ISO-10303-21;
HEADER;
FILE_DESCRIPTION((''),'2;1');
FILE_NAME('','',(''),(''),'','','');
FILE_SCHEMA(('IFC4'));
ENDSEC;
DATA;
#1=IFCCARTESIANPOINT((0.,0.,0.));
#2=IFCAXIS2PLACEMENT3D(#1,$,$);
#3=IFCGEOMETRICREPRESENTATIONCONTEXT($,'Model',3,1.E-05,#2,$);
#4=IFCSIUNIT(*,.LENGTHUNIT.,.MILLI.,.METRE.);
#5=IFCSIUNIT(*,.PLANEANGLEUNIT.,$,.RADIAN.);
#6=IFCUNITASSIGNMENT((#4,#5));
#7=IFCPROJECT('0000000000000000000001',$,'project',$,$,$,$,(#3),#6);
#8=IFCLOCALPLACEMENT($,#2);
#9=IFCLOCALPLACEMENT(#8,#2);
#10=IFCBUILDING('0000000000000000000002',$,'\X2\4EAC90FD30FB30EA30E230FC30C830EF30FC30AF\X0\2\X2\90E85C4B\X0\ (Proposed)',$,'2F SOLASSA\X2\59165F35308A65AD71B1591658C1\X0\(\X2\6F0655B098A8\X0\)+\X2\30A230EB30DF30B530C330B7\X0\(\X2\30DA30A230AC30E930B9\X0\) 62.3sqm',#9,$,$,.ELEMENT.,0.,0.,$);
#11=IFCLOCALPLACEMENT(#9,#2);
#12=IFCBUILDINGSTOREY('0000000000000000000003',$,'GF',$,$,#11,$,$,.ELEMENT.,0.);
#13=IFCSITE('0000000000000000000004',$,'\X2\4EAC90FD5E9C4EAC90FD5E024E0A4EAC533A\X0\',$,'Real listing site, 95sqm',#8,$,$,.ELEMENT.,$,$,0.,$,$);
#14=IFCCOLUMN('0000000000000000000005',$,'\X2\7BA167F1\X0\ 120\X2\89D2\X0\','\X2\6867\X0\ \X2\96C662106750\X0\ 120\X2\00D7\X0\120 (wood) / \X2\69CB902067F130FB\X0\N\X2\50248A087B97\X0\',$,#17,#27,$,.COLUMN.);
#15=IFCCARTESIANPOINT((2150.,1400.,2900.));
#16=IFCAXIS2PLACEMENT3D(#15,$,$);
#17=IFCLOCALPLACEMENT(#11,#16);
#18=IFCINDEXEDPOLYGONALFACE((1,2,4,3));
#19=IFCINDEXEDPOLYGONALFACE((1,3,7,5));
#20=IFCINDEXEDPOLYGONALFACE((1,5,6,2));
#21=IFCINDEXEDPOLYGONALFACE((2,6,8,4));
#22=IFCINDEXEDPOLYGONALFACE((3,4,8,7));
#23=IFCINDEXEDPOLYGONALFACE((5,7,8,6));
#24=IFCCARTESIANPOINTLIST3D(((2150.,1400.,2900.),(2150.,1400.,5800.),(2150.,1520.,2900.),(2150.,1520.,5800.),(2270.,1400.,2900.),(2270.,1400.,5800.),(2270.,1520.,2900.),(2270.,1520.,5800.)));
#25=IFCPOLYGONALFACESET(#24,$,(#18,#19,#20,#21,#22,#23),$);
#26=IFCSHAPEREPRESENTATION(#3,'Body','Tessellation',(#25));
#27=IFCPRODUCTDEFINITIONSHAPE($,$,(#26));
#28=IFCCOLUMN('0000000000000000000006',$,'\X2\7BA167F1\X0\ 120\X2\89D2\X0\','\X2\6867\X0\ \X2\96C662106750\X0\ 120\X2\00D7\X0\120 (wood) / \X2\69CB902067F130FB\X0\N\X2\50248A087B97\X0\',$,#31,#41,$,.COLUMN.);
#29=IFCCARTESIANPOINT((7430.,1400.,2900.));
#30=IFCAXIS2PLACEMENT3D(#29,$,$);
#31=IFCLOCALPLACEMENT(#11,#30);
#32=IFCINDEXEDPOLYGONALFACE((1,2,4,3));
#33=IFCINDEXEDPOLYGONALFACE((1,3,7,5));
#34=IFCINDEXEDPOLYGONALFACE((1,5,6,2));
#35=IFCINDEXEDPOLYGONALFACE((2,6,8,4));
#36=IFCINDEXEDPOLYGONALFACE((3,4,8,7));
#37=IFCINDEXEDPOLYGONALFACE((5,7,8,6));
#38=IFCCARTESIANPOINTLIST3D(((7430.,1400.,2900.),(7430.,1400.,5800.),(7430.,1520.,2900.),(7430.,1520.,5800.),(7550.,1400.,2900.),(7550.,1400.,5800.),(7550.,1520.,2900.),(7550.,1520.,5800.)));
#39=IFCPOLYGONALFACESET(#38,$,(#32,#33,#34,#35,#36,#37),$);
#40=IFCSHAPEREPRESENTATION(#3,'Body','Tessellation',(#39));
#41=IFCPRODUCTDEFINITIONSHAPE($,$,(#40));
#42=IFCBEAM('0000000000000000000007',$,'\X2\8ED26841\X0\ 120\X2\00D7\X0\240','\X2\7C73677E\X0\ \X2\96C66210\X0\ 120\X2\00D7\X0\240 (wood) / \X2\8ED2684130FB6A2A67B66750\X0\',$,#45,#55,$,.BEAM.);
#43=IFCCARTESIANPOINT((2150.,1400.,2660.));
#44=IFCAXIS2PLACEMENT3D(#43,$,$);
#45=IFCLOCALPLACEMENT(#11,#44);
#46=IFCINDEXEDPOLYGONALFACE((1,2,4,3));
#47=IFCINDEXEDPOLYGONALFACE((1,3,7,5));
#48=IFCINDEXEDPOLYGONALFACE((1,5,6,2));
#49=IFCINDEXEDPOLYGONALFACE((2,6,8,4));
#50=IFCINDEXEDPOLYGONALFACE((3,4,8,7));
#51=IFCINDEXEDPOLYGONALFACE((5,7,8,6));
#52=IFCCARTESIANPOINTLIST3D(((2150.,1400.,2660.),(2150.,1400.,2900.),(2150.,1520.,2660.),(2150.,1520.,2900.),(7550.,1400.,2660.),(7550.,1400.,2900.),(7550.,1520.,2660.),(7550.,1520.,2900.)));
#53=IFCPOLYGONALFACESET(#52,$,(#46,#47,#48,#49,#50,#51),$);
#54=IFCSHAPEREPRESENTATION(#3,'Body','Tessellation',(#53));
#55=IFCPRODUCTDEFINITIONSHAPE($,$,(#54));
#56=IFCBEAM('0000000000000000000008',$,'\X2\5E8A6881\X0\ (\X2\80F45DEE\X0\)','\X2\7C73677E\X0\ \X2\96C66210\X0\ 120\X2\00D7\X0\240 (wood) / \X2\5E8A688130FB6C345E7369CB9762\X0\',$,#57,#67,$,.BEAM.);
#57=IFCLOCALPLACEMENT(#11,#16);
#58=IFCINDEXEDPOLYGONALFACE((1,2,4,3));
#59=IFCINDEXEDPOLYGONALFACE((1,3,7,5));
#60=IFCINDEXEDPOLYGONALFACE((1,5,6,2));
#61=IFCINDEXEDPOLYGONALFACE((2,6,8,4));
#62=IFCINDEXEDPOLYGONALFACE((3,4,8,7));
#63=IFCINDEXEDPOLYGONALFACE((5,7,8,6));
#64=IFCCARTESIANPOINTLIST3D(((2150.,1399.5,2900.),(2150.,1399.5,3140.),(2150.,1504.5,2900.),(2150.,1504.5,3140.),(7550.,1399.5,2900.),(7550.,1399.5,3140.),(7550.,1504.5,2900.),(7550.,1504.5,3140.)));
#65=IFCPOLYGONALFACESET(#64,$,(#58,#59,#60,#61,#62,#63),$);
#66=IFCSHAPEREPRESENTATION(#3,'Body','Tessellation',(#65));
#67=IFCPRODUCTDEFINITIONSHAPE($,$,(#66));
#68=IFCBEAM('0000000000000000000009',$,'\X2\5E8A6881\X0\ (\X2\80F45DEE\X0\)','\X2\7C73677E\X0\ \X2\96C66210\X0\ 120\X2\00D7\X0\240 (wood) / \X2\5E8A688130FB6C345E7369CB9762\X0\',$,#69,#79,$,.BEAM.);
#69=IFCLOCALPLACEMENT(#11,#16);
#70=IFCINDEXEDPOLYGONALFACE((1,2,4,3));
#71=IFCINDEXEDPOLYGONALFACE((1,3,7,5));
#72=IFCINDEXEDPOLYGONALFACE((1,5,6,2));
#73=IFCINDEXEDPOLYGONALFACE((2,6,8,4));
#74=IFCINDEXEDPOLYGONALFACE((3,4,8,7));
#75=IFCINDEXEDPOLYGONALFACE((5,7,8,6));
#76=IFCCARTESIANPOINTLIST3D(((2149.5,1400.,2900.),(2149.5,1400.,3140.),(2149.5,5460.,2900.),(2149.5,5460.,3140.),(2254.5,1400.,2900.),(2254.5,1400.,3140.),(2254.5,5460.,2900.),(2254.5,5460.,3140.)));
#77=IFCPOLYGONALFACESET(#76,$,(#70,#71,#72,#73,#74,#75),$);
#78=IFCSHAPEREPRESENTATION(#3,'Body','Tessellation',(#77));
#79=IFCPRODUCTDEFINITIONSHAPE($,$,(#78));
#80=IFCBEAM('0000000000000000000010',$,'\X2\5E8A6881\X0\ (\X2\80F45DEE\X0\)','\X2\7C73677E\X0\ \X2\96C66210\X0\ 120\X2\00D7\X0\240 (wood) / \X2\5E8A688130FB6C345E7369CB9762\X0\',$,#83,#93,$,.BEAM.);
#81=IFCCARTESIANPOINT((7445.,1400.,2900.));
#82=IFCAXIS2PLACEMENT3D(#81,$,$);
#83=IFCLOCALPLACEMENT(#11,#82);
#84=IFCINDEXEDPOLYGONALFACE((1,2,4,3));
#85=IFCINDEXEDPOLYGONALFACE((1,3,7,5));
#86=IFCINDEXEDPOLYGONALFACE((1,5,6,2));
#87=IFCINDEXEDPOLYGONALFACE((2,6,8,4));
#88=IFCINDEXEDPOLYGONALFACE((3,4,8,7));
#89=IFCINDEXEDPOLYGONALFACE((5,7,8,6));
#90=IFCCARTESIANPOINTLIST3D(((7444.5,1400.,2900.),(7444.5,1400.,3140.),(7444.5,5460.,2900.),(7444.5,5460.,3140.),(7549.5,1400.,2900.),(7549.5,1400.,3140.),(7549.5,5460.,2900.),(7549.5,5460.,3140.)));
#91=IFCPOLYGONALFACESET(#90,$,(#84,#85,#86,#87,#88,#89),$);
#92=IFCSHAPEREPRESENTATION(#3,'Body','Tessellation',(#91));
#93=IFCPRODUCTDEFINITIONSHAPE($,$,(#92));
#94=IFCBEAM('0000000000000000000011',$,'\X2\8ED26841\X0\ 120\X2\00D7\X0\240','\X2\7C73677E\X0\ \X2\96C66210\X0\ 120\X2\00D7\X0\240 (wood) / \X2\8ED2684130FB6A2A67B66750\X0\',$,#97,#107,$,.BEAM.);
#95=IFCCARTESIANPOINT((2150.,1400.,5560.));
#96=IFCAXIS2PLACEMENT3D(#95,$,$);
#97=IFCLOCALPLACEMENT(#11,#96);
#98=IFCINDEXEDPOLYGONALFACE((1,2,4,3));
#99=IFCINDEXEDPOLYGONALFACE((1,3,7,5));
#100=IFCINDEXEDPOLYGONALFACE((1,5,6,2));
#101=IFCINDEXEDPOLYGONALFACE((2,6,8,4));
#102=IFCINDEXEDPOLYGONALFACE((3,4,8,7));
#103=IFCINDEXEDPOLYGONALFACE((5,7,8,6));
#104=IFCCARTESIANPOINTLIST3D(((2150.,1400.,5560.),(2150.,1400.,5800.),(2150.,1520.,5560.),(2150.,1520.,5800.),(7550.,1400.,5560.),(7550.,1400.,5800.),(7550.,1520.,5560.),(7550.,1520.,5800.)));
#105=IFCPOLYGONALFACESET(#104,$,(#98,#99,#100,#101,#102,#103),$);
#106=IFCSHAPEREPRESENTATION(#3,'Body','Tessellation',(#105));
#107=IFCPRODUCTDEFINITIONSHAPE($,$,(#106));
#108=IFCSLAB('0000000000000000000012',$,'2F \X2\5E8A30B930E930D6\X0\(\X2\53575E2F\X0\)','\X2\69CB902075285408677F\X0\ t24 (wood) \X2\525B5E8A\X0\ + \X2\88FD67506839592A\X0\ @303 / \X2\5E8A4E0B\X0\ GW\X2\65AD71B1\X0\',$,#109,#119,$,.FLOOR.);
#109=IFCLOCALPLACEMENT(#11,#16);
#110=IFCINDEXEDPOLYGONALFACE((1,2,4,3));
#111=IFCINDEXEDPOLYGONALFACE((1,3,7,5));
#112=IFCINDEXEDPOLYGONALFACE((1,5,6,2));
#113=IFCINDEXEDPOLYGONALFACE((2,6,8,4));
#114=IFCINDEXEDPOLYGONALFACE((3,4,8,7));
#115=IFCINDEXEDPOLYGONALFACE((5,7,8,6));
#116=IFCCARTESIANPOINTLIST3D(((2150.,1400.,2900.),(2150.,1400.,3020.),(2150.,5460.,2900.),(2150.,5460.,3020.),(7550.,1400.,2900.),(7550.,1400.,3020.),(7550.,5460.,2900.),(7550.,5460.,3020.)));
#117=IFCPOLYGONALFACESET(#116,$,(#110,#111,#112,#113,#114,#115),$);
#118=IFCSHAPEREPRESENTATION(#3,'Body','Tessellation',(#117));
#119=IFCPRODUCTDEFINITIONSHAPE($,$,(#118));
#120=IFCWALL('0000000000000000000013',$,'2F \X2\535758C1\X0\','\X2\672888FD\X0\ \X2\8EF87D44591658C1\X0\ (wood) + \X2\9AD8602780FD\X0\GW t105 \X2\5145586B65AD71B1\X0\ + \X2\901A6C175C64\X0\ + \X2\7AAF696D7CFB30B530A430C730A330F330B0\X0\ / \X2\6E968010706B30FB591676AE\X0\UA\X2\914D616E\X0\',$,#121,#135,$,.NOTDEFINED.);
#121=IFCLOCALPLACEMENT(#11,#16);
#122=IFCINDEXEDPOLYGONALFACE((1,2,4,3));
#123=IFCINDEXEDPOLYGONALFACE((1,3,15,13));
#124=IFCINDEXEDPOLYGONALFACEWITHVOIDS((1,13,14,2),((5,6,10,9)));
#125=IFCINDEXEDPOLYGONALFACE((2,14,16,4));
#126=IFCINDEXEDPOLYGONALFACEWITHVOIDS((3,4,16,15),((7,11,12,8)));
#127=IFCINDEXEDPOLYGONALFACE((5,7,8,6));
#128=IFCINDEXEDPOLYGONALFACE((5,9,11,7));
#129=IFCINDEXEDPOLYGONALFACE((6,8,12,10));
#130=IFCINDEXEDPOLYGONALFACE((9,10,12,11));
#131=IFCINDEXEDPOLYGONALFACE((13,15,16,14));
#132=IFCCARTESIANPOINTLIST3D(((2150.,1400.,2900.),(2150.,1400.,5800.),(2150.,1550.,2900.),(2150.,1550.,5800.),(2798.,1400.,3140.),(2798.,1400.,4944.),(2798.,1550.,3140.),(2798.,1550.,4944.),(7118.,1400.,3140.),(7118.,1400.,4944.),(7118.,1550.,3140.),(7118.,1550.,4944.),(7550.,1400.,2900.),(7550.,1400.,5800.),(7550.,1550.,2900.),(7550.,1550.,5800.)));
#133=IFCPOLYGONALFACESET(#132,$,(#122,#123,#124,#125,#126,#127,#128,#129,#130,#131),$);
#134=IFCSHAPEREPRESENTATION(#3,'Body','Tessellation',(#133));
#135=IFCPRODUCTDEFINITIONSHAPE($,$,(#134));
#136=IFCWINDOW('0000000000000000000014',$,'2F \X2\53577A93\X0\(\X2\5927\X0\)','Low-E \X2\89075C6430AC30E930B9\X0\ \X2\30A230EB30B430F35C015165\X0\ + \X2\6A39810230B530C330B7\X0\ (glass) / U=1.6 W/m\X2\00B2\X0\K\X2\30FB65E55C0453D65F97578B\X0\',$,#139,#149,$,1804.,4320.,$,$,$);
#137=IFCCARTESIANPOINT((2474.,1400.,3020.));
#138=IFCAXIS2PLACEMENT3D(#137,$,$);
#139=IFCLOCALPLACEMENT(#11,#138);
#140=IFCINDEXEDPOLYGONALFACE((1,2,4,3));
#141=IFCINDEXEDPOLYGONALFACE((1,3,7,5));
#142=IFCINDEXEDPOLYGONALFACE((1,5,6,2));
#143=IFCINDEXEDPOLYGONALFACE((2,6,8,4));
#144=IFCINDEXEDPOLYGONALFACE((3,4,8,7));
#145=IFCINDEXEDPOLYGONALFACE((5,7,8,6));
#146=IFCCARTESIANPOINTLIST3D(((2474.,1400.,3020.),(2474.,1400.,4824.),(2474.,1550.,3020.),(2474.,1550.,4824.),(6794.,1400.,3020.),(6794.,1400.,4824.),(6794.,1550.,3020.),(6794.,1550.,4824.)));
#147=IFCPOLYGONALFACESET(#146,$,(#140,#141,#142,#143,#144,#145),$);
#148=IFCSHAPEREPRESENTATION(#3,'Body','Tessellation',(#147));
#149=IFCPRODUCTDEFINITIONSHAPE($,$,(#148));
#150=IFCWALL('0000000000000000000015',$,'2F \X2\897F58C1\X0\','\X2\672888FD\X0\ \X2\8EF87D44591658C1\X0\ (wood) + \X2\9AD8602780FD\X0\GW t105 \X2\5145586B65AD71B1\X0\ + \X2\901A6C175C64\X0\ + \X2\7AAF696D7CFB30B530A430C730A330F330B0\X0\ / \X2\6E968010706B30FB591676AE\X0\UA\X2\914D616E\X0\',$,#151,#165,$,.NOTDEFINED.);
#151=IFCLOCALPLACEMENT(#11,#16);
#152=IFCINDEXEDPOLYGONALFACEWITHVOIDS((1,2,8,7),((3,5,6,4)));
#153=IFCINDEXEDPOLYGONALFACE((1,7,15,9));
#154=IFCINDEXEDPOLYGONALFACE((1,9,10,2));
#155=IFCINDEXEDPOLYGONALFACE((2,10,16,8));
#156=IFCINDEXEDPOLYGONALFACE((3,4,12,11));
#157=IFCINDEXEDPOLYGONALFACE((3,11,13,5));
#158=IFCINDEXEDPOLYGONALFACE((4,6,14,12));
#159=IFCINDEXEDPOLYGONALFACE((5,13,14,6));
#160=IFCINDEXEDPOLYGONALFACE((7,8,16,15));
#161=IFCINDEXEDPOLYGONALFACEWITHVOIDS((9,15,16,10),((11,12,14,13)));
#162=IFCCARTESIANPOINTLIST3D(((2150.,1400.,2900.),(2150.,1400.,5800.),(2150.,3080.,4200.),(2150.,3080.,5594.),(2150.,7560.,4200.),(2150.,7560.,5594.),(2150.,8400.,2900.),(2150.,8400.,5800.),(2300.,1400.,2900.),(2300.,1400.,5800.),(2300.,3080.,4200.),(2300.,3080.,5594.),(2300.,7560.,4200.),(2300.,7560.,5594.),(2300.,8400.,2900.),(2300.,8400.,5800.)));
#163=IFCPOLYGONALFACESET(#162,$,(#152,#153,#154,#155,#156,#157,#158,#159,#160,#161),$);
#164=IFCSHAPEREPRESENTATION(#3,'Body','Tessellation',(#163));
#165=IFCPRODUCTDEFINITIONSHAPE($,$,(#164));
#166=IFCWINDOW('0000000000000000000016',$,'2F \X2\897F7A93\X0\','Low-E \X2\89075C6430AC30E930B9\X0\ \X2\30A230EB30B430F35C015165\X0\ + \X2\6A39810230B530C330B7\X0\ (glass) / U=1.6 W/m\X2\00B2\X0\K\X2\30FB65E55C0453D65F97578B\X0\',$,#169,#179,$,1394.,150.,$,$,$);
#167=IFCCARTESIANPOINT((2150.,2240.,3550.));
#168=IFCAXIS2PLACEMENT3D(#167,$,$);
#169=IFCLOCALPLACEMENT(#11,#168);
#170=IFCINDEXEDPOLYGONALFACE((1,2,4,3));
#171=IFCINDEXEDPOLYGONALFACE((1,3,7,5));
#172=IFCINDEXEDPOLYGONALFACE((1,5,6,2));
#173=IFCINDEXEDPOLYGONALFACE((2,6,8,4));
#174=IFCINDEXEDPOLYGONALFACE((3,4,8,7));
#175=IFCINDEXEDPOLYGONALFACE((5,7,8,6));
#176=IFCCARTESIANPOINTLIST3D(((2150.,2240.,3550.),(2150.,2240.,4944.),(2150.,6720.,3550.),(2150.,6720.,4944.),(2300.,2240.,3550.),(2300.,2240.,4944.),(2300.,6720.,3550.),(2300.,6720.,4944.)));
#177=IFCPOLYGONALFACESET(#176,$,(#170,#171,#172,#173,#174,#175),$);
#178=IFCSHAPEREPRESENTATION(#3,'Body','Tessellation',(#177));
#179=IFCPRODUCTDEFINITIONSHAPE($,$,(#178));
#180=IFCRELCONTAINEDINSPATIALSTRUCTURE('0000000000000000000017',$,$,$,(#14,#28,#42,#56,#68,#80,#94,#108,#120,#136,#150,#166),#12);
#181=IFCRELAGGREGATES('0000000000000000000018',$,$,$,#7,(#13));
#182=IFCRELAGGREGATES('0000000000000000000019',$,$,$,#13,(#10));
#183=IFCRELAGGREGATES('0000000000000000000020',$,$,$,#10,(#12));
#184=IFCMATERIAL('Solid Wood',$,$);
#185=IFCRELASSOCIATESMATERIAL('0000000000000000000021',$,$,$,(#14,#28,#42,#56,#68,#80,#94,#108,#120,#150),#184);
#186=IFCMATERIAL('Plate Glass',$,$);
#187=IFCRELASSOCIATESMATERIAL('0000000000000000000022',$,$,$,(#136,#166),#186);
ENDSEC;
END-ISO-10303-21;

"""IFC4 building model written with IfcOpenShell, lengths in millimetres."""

from ifc_helpers import new_model, si_unit, frame, frame_2d, origin, place, context, project, spatial, rectangle, extrude, material, element, fill, save


model = new_model("IFC4")

# Units and contexts
model_context = context("Model", 3, precision=1e-05, world=origin())
ifc_project = project(units=[si_unit("LENGTHUNIT", "METRE", prefix="MILLI"), si_unit("PLANEANGLEUNIT", "RADIAN")], contexts=[model_context])

# Site, building, storey
site_placement = place(None, origin())
site = spatial("IfcSite", under=ifc_project, at=site_placement, Name="京都府京都市上京区", ObjectType="Real listing site, 95sqm", CompositionType="ELEMENT", RefElevation=0.0)
building_placement = place(site_placement, origin())
building = spatial("IfcBuilding", under=site, at=building_placement, Name="京都・リモートワーク2部屋 (Proposed)", ObjectType="2F SOLASSA外張り断熱外壁(漆喰風)+アルミサッシ(ペアガラス) 62.3sqm", CompositionType="ELEMENT", ElevationOfRefHeight=0.0, ElevationOfTerrain=0.0)
storey_placement = place(building_placement, origin())
storey = spatial("IfcBuildingStorey", under=building, at=storey_placement, Name="GF", CompositionType="ELEMENT", Elevation=0.0)

# Columns
ifc_material_1 = material(Name="Solid Wood")
column_1_placement = place(storey_placement, frame((2150.0, 1400.0, 2900.0)))
element("IfcColumn", 1, at=column_1_placement, inside=storey, material=ifc_material_1, Name="管柱 120角", Description="桧 集成材 120×120 (wood) / 構造柱・N値計算", PredefinedType="COLUMN", context=model_context, shape_type="SweptSolid", body=[
    extrude(rectangle(XDim=120.0, YDim=120.0, at=frame_2d((60.0, 60.0))), frame((2150.0, 1400.0, 2900.0)), (0.0, 0.0, 1.0), 2900.0),
])
column_2_placement = place(storey_placement, frame((7430.0, 1400.0, 2900.0)))
element("IfcColumn", 2, at=column_2_placement, inside=storey, material=ifc_material_1, Name="管柱 120角", Description="桧 集成材 120×120 (wood) / 構造柱・N値計算", PredefinedType="COLUMN", context=model_context, shape_type="SweptSolid", body=[
    extrude(rectangle(XDim=120.0, YDim=120.0, at=frame_2d((60.0, 60.0))), frame((7430.0, 1400.0, 2900.0)), (0.0, 0.0, 1.0), 2900.0),
])

# Beams
beam_1_placement = place(storey_placement, frame((2150.0, 1400.0, 2660.0)))
element("IfcBeam", 3, at=beam_1_placement, inside=storey, material=ifc_material_1, Name="軒桁 120×240", Description="米松 集成 120×240 (wood) / 軒桁・横架材", PredefinedType="BEAM", context=model_context, shape_type="SweptSolid", body=[
    extrude(rectangle(XDim=5400.0, YDim=120.0, at=frame_2d((2700.0, 60.0))), frame((2150.0, 1400.0, 2660.0)), (0.0, 0.0, 1.0), 240.0),
])
beam_2_placement = place(storey_placement, frame((2150.0, 1400.0, 2900.0)))
element("IfcBeam", 4, at=beam_2_placement, inside=storey, material=ifc_material_1, Name="床梁 (胴差)", Description="米松 集成 120×240 (wood) / 床梁・水平構面", PredefinedType="BEAM", context=model_context, shape_type="SweptSolid", body=[
    extrude(rectangle(XDim=5400.0, YDim=105.0, at=frame_2d((2700.0, 52.0))), frame((2150.0, 1400.0, 2900.0)), (0.0, 0.0, 1.0), 240.0),
])
beam_3_placement = place(storey_placement, frame((2150.0, 1400.0, 2900.0)))
element("IfcBeam", 5, at=beam_3_placement, inside=storey, material=ifc_material_1, Name="床梁 (胴差)", Description="米松 集成 120×240 (wood) / 床梁・水平構面", PredefinedType="BEAM", context=model_context, shape_type="SweptSolid", body=[
    extrude(rectangle(XDim=105.0, YDim=4060.0, at=frame_2d((52.0, 2030.0))), frame((2150.0, 1400.0, 2900.0)), (0.0, 0.0, 1.0), 240.0),
])
beam_4_placement = place(storey_placement, frame((7445.0, 1400.0, 2900.0)))
element("IfcBeam", 6, at=beam_4_placement, inside=storey, material=ifc_material_1, Name="床梁 (胴差)", Description="米松 集成 120×240 (wood) / 床梁・水平構面", PredefinedType="BEAM", context=model_context, shape_type="SweptSolid", body=[
    extrude(rectangle(XDim=105.0, YDim=4060.0, at=frame_2d((52.0, 2030.0))), frame((7445.0, 1400.0, 2900.0)), (0.0, 0.0, 1.0), 240.0),
])
beam_5_placement = place(storey_placement, frame((2150.0, 1400.0, 5560.0)))
element("IfcBeam", 7, at=beam_5_placement, inside=storey, material=ifc_material_1, Name="軒桁 120×240", Description="米松 集成 120×240 (wood) / 軒桁・横架材", PredefinedType="BEAM", context=model_context, shape_type="SweptSolid", body=[
    extrude(rectangle(XDim=5400.0, YDim=120.0, at=frame_2d((2700.0, 60.0))), frame((2150.0, 1400.0, 5560.0)), (0.0, 0.0, 1.0), 240.0),
])

# Slab
slab_placement = place(storey_placement, frame((2150.0, 1400.0, 2900.0)))
element("IfcSlab", 8, at=slab_placement, inside=storey, material=ifc_material_1, Name="2F 床スラブ(南帯)", Description="構造用合板 t24 (wood) 剛床 + 製材根太 @303 / 床下 GW断熱", PredefinedType="FLOOR", context=model_context, shape_type="SweptSolid", body=[
    extrude(rectangle(XDim=5400.0, YDim=4060.0, at=frame_2d((2700.0, 2030.0))), frame((2150.0, 1400.0, 2900.0)), (0.0, 0.0, 1.0), 120.0),
])

# Walls, openings, windows
wall_1_placement = place(storey_placement, frame((2150.0, 1400.0, 2900.0)))
wall_1 = element("IfcWall", 9, at=wall_1_placement, inside=storey, material=ifc_material_1, Name="2F 南壁", Description="木製 軸組外壁 (wood) + 高性能GW t105 充填断熱 + 通気層 + 窯業系サイディング / 準耐火・外皮UA配慮", PredefinedType="NOTDEFINED", context=model_context, shape_type="SweptSolid", body=[
    extrude(rectangle(XDim=5400.0, YDim=150.0, at=frame_2d((2700.0, 75.0))), frame((2150.0, 1400.0, 2900.0)), (0.0, 0.0, 1.0), 2900.0),
])
opening_1_placement = place(storey_placement, frame((2474.0, 1400.0, 3020.0)))
opening_1 = element("IfcOpeningElement", 10, at=opening_1_placement, cuts=wall_1, PredefinedType="NOTDEFINED", context=model_context, shape_type="SweptSolid", body=[
    extrude(rectangle(XDim=4320.0, YDim=150.0, at=frame_2d((2160.0, 75.0))), frame((2474.0, 1400.0, 3020.0)), (0.0, 0.0, 1.0), 1804.0),
])
ifc_material_2 = material(Name="Plate Glass")
window_1_placement = place(storey_placement, frame((2474.0, 1400.0, 3020.0)))
window_1 = element("IfcWindow", 11, at=window_1_placement, inside=storey, material=ifc_material_2, Name="2F 南窓(大)", Description="Low-E 複層ガラス アルゴン封入 + 樹脂サッシ (glass) / U=1.6 W/m²K・日射取得型", OverallHeight=1804.0, OverallWidth=4320.0, context=model_context, shape_type="SweptSolid", body=[
    extrude(rectangle(XDim=4320.0, YDim=150.0, at=frame_2d((2160.0, 75.0))), frame((2474.0, 1400.0, 3020.0)), (0.0, 0.0, 1.0), 1804.0),
])
fill(opening_1, window_1)
wall_2_placement = place(storey_placement, frame((2150.0, 1400.0, 2900.0)))
wall_2 = element("IfcWall", 12, at=wall_2_placement, inside=storey, material=ifc_material_1, Name="2F 西壁", Description="木製 軸組外壁 (wood) + 高性能GW t105 充填断熱 + 通気層 + 窯業系サイディング / 準耐火・外皮UA配慮", PredefinedType="NOTDEFINED", context=model_context, shape_type="SweptSolid", body=[
    extrude(rectangle(XDim=150.0, YDim=7000.0, at=frame_2d((75.0, 3500.0))), frame((2150.0, 1400.0, 2900.0)), (0.0, 0.0, 1.0), 2900.0),
])
opening_2_placement = place(storey_placement, frame((2150.0, 2240.0, 3550.0)))
opening_2 = element("IfcOpeningElement", 13, at=opening_2_placement, cuts=wall_2, PredefinedType="NOTDEFINED", context=model_context, shape_type="SweptSolid", body=[
    extrude(rectangle(XDim=150.0, YDim=4480.0, at=frame_2d((75.0, 2240.0))), frame((2150.0, 2240.0, 3550.0)), (0.0, 0.0, 1.0), 1394.0),
])
window_2_placement = place(storey_placement, frame((2150.0, 2240.0, 3550.0)))
window_2 = element("IfcWindow", 14, at=window_2_placement, inside=storey, material=ifc_material_2, Name="2F 西窓", Description="Low-E 複層ガラス アルゴン封入 + 樹脂サッシ (glass) / U=1.6 W/m²K・日射取得型", OverallHeight=1394.0, OverallWidth=150.0, context=model_context, shape_type="SweptSolid", body=[
    extrude(rectangle(XDim=150.0, YDim=4480.0, at=frame_2d((75.0, 2240.0))), frame((2150.0, 2240.0, 3550.0)), (0.0, 0.0, 1.0), 1394.0),
])
fill(opening_2, window_2)

save(model, "model.ifc")
